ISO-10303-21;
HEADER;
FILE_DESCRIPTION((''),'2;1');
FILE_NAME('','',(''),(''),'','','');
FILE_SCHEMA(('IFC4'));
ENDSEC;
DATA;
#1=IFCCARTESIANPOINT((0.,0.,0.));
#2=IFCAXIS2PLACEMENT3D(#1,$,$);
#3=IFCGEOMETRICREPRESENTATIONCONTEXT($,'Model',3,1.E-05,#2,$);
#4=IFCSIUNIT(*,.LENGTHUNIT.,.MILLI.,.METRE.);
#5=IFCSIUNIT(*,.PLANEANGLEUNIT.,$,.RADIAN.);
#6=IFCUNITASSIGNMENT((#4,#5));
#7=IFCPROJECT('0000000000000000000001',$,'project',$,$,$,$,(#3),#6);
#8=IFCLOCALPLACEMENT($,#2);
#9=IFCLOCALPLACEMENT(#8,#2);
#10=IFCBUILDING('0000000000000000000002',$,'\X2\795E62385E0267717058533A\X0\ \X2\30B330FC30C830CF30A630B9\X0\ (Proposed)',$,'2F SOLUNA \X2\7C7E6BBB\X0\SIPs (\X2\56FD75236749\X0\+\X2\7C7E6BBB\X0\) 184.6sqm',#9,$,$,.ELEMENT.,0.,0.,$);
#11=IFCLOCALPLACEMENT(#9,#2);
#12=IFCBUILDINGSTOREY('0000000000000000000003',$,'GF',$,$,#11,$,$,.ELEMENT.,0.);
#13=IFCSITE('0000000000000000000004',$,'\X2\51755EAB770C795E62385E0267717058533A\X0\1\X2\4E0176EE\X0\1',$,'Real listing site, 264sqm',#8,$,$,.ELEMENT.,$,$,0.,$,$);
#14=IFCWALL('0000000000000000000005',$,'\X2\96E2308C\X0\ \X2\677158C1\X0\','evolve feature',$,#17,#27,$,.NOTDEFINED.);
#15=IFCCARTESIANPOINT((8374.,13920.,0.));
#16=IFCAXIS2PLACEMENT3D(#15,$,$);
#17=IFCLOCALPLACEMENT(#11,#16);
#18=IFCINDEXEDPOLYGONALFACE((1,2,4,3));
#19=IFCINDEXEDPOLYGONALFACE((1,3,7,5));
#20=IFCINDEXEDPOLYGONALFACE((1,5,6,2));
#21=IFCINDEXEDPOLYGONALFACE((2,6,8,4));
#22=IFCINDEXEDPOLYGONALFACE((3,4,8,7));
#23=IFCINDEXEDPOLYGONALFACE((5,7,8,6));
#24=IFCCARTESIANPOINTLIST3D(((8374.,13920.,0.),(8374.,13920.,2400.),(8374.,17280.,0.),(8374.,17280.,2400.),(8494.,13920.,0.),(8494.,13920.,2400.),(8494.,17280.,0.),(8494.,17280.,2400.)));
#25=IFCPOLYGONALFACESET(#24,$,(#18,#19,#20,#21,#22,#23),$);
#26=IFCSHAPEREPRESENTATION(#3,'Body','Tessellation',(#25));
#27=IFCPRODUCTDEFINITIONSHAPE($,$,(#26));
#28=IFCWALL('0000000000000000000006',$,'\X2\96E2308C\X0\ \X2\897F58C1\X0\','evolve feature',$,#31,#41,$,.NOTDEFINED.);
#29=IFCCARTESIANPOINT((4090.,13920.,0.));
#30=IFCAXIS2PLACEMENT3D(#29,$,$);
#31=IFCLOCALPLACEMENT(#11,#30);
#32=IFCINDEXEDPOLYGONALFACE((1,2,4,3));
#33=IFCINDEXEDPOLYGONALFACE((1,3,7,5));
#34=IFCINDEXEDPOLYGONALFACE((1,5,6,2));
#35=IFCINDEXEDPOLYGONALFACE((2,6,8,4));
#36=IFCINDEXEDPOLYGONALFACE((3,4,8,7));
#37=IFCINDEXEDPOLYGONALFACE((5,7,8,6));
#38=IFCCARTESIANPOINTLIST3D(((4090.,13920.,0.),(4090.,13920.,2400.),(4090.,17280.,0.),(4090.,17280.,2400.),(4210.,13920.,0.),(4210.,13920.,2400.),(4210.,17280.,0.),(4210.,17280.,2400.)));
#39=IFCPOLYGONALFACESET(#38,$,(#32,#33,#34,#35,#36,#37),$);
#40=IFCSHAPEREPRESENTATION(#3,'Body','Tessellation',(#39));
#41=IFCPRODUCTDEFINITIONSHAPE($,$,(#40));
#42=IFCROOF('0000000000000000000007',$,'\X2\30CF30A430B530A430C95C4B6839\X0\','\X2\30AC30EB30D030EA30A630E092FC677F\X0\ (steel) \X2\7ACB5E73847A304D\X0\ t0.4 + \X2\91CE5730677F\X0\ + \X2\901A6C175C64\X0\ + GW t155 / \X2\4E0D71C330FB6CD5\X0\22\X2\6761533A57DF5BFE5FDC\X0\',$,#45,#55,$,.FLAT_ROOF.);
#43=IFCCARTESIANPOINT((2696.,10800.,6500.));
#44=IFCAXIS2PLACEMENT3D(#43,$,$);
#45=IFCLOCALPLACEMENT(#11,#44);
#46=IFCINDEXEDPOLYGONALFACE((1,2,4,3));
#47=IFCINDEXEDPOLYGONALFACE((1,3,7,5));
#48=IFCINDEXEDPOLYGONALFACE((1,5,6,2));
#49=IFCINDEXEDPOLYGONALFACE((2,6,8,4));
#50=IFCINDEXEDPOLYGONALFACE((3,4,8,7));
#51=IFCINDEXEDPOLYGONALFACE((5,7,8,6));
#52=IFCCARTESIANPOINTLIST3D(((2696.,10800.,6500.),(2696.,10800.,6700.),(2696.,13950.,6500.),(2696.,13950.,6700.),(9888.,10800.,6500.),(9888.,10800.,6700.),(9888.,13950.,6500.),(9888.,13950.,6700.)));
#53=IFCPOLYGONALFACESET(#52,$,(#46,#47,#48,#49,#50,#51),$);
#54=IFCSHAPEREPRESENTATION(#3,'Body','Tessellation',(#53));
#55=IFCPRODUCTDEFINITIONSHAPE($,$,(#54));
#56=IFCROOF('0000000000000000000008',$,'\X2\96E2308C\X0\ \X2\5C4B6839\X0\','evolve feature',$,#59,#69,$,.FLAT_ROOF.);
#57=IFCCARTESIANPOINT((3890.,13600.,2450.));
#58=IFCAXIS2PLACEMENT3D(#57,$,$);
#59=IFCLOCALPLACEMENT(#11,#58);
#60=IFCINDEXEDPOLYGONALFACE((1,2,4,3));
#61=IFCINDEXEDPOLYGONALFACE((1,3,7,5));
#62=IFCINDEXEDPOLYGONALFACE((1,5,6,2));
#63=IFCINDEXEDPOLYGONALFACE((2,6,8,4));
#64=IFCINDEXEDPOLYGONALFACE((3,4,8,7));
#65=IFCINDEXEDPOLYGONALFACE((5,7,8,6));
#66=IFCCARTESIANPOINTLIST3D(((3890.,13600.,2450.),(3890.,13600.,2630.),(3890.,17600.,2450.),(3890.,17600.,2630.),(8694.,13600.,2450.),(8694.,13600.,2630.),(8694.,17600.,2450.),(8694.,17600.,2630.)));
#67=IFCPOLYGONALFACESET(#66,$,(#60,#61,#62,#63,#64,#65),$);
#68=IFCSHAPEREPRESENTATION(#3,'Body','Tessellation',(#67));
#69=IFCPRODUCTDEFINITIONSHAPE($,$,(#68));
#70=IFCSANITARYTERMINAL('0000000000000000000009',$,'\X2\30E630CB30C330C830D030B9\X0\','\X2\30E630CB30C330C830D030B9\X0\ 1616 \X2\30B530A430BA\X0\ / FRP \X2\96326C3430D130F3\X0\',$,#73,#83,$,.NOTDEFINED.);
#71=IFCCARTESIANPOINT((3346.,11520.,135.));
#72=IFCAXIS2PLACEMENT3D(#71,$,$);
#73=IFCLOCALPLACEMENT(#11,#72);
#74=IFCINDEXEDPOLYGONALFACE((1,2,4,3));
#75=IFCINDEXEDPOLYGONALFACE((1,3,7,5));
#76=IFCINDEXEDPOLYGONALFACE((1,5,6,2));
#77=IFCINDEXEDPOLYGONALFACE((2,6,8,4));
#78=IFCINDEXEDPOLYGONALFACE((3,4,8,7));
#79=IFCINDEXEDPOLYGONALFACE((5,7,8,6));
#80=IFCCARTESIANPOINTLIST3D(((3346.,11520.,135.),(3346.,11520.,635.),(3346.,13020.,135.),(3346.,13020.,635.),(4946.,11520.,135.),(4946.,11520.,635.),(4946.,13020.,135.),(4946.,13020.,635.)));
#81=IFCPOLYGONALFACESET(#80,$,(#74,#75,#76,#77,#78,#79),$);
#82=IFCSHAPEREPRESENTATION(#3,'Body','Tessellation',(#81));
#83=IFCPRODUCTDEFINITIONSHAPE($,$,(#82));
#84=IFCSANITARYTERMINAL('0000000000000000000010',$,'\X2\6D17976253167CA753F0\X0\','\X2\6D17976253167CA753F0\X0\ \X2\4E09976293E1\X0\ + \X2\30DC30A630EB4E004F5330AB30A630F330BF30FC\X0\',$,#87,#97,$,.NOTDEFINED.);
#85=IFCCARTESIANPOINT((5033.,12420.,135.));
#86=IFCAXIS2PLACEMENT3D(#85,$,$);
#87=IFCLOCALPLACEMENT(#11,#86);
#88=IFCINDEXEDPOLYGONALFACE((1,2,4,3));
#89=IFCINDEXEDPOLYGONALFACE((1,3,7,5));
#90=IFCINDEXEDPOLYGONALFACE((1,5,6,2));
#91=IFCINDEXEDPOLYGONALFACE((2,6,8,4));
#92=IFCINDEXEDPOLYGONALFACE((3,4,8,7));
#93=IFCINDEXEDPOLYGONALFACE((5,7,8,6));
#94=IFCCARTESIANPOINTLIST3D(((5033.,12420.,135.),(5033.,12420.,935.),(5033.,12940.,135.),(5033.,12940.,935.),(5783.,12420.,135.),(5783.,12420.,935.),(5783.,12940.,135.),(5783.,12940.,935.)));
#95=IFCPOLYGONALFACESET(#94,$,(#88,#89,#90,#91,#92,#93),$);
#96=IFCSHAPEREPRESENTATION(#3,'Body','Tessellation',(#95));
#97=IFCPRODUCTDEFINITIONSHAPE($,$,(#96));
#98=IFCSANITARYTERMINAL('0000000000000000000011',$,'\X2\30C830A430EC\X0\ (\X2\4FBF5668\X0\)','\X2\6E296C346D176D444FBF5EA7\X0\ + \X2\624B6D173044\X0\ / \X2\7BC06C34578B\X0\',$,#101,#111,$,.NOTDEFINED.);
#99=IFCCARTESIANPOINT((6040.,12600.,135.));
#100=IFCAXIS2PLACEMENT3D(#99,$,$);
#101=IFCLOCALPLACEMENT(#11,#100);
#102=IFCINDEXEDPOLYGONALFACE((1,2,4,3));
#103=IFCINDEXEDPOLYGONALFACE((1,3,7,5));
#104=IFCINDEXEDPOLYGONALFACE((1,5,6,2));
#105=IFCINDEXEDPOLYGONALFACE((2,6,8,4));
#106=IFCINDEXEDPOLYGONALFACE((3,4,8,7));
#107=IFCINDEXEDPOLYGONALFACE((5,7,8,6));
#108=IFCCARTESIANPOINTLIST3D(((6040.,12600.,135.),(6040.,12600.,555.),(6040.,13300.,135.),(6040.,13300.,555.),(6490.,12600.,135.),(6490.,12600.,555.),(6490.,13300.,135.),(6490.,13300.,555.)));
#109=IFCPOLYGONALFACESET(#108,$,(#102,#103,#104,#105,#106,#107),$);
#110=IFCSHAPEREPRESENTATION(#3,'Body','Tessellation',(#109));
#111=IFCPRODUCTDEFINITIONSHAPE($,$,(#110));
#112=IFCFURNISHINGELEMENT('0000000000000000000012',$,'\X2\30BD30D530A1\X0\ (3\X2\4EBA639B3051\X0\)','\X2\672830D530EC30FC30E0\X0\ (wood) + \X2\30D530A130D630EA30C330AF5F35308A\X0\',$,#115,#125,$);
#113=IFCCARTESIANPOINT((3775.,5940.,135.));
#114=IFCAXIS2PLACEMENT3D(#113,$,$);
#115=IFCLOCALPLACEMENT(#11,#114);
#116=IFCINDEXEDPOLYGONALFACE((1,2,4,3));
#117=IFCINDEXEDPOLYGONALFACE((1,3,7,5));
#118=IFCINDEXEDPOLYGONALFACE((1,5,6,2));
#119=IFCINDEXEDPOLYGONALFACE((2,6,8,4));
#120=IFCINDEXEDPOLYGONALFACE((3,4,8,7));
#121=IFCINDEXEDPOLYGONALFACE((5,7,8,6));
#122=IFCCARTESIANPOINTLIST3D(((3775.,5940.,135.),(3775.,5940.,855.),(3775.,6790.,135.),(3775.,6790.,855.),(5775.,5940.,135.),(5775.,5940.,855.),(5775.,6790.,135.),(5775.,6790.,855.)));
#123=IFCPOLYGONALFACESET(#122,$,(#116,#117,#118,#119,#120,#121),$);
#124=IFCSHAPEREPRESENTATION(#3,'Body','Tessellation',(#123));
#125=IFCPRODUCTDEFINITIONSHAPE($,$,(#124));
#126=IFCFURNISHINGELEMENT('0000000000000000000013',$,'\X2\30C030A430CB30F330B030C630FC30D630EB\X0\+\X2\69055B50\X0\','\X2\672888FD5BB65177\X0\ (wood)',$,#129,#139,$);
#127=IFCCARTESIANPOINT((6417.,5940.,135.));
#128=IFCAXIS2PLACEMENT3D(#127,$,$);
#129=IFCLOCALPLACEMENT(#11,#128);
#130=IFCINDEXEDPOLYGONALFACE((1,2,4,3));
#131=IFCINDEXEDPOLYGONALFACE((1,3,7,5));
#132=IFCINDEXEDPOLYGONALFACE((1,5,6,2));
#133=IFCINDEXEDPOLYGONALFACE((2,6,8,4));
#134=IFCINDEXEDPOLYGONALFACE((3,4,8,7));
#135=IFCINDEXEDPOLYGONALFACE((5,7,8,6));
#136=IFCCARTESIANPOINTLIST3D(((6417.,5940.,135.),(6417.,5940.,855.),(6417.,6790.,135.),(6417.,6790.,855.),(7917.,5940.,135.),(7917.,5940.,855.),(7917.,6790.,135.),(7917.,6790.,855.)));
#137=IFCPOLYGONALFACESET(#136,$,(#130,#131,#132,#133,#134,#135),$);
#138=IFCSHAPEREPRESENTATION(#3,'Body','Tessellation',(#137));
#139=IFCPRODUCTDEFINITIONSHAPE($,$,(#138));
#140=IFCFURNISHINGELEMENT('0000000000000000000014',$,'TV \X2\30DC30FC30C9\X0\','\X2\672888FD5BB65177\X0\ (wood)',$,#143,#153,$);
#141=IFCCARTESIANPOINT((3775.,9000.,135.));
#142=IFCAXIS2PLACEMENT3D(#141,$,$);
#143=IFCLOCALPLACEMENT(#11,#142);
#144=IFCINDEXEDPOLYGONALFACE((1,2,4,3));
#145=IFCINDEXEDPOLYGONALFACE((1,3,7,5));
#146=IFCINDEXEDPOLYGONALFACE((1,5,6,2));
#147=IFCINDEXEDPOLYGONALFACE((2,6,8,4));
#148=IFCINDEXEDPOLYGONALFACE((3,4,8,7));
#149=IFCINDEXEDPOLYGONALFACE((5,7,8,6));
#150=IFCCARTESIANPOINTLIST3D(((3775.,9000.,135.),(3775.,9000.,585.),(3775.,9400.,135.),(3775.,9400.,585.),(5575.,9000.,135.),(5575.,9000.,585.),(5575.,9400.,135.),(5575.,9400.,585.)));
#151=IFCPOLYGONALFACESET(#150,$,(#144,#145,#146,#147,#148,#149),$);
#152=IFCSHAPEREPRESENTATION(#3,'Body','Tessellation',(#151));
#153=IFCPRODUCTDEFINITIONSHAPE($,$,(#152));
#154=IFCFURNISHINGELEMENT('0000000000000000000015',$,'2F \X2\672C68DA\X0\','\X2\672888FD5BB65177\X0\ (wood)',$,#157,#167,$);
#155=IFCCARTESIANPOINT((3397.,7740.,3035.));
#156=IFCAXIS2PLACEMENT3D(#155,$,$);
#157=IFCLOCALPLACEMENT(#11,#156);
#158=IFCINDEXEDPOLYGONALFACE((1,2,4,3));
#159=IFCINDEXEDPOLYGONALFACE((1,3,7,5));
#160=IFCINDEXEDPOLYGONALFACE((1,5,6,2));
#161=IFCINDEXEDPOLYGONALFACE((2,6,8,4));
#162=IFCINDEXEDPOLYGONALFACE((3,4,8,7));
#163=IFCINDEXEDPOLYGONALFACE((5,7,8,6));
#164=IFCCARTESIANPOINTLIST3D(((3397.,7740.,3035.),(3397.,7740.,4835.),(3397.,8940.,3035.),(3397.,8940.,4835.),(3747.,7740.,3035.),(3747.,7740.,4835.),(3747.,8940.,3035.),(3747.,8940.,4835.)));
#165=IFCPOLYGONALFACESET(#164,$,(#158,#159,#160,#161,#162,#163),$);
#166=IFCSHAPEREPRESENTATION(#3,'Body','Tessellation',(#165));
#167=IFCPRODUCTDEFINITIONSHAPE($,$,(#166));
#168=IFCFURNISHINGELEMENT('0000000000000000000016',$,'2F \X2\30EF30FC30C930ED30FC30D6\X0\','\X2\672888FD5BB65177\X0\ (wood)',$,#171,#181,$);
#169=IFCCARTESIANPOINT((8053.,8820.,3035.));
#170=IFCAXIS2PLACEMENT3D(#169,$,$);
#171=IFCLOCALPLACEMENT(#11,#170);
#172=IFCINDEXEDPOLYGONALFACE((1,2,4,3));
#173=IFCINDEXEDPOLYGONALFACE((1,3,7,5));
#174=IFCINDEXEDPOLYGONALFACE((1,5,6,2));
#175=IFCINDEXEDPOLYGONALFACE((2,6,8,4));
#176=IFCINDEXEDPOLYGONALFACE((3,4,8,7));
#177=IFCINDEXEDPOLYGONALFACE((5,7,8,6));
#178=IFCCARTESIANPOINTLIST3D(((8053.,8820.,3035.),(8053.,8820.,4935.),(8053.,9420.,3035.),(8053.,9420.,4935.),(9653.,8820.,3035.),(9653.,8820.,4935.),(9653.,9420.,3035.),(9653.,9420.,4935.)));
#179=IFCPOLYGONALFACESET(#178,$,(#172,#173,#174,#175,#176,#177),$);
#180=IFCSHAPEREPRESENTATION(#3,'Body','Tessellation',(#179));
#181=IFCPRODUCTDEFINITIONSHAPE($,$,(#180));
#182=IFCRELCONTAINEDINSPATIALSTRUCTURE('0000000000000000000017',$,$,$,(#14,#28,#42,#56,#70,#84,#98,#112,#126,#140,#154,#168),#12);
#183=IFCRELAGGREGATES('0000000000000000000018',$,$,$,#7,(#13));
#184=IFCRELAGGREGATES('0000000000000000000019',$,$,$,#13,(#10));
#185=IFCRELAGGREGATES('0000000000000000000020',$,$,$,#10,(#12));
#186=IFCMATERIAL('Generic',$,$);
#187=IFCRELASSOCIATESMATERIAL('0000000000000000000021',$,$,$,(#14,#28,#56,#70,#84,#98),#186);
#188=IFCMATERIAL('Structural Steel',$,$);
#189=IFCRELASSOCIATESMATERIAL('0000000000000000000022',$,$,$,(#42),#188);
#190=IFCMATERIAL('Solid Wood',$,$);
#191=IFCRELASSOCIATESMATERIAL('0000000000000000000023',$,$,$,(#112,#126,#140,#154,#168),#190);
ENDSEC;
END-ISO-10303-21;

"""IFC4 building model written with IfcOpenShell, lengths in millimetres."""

from ifc_helpers import new_model, si_unit, frame, frame_2d, origin, place, context, project, spatial, rectangle, extrude, material, element, save


model = new_model("IFC4")

# Units and contexts
model_context = context("Model", 3, precision=1e-05, world=origin())
ifc_project = project(units=[si_unit("LENGTHUNIT", "METRE", prefix="MILLI"), si_unit("PLANEANGLEUNIT", "RADIAN")], contexts=[model_context])

# Site, building, storey
site_placement = place(None, origin())
site = spatial("IfcSite", under=ifc_project, at=site_placement, Name="兵庫県神戸市東灘区1丁目1", ObjectType="Real listing site, 264sqm", CompositionType="ELEMENT", RefElevation=0.0)
building_placement = place(site_placement, origin())
building = spatial("IfcBuilding", under=site, at=building_placement, Name="神戸市東灘区 コートハウス (Proposed)", ObjectType="2F SOLUNA 籾殻SIPs (国産杉+籾殻) 184.6sqm", CompositionType="ELEMENT", ElevationOfRefHeight=0.0, ElevationOfTerrain=0.0)
storey_placement = place(building_placement, origin())
storey = spatial("IfcBuildingStorey", under=building, at=storey_placement, Name="GF", CompositionType="ELEMENT", Elevation=0.0)

# Shared definitions
ifc_material_1 = material(Name="Generic")

# Shared definitions
ifc_material_2 = material(Name="Solid Wood")

# Walls
wall_1_placement = place(storey_placement, frame((8374.0, 13920.0, 0.0)))
element("IfcWall", 1, at=wall_1_placement, inside=storey, material=ifc_material_1, Name="離れ 東壁", Description="evolve feature", PredefinedType="NOTDEFINED", context=model_context, shape_type="SweptSolid", body=[
    extrude(rectangle(XDim=120.0, YDim=3360.0, at=frame_2d((60.0, 1680.0))), frame((8374.0, 13920.0, 0.0)), (0.0, 0.0, 1.0), 2400.0),
])
wall_2_placement = place(storey_placement, frame((4090.0, 13920.0, 0.0)))
element("IfcWall", 2, at=wall_2_placement, inside=storey, material=ifc_material_1, Name="離れ 西壁", Description="evolve feature", PredefinedType="NOTDEFINED", context=model_context, shape_type="SweptSolid", body=[
    extrude(rectangle(XDim=120.0, YDim=3360.0, at=frame_2d((60.0, 1680.0))), frame((4090.0, 13920.0, 0.0)), (0.0, 0.0, 1.0), 2400.0),
])

# Roofs
ifc_material_3 = material(Name="Structural Steel")
roof_1_placement = place(storey_placement, frame((2696.0, 10800.0, 6500.0)))
element("IfcRoof", 3, at=roof_1_placement, inside=storey, material=ifc_material_3, Name="ハイサイド屋根", Description="ガルバリウム鋼板 (steel) 立平葺き t0.4 + 野地板 + 通気層 + GW t155 / 不燃・法22条区域対応", PredefinedType="FLAT_ROOF", context=model_context, shape_type="SweptSolid", body=[
    extrude(rectangle(XDim=7192.0, YDim=3150.0, at=frame_2d((3596.0, 1575.0))), frame((2696.0, 10800.0, 6500.0)), (0.0, 0.0, 1.0), 200.0),
])
roof_2_placement = place(storey_placement, frame((3890.0, 13600.0, 2450.0)))
element("IfcRoof", 4, at=roof_2_placement, inside=storey, material=ifc_material_1, Name="離れ 屋根", Description="evolve feature", PredefinedType="FLAT_ROOF", context=model_context, shape_type="SweptSolid", body=[
    extrude(rectangle(XDim=4804.0, YDim=4000.0, at=frame_2d((2402.0, 2000.0))), frame((3890.0, 13600.0, 2450.0)), (0.0, 0.0, 1.0), 180.0),
])

# Sanitary terminals
sanitary_terminal_1_placement = place(storey_placement, frame((3346.0, 11520.0, 135.0)))
element("IfcSanitaryTerminal", 5, at=sanitary_terminal_1_placement, inside=storey, material=ifc_material_1, Name="ユニットバス", Description="ユニットバス 1616 サイズ / FRP 防水パン", PredefinedType="NOTDEFINED", context=model_context, shape_type="SweptSolid", body=[
    extrude(rectangle(XDim=1600.0, YDim=1500.0, at=frame_2d((800.0, 750.0))), frame((3346.0, 11520.0, 135.0)), (0.0, 0.0, 1.0), 500.0),
])
sanitary_terminal_2_placement = place(storey_placement, frame((5033.0, 12420.0, 135.0)))
element("IfcSanitaryTerminal", 6, at=sanitary_terminal_2_placement, inside=storey, material=ifc_material_1, Name="洗面化粧台", Description="洗面化粧台 三面鏡 + ボウル一体カウンター", PredefinedType="NOTDEFINED", context=model_context, shape_type="SweptSolid", body=[
    extrude(rectangle(XDim=750.0, YDim=520.0, at=frame_2d((375.0, 260.0))), frame((5033.0, 12420.0, 135.0)), (0.0, 0.0, 1.0), 800.0),
])
sanitary_terminal_3_placement = place(storey_placement, frame((6040.0, 12600.0, 135.0)))
element("IfcSanitaryTerminal", 7, at=sanitary_terminal_3_placement, inside=storey, material=ifc_material_1, Name="トイレ (便器)", Description="温水洗浄便座 + 手洗い / 節水型", PredefinedType="NOTDEFINED", context=model_context, shape_type="SweptSolid", body=[
    extrude(rectangle(XDim=450.0, YDim=700.0, at=frame_2d((225.0, 350.0))), frame((6040.0, 12600.0, 135.0)), (0.0, 0.0, 1.0), 420.0),
])

# Furnishing elements
furnishing_1_placement = place(storey_placement, frame((3775.0, 5940.0, 135.0)))
element("IfcFurnishingElement", 8, at=furnishing_1_placement, inside=storey, material=ifc_material_2, Name="ソファ (3人掛け)", Description="木フレーム (wood) + ファブリック張り", context=model_context, shape_type="SweptSolid", body=[
    extrude(rectangle(XDim=2000.0, YDim=850.0, at=frame_2d((1000.0, 425.0))), frame((3775.0, 5940.0, 135.0)), (0.0, 0.0, 1.0), 720.0),
])
furnishing_2_placement = place(storey_placement, frame((6417.0, 5940.0, 135.0)))
element("IfcFurnishingElement", 9, at=furnishing_2_placement, inside=storey, material=ifc_material_2, Name="ダイニングテーブル+椅子", Description="木製家具 (wood)", context=model_context, shape_type="SweptSolid", body=[
    extrude(rectangle(XDim=1500.0, YDim=850.0, at=frame_2d((750.0, 425.0))), frame((6417.0, 5940.0, 135.0)), (0.0, 0.0, 1.0), 720.0),
])
furnishing_3_placement = place(storey_placement, frame((3775.0, 9000.0, 135.0)))
element("IfcFurnishingElement", 10, at=furnishing_3_placement, inside=storey, material=ifc_material_2, Name="TV ボード", Description="木製家具 (wood)", context=model_context, shape_type="SweptSolid", body=[
    extrude(rectangle(XDim=1800.0, YDim=400.0, at=frame_2d((900.0, 200.0))), frame((3775.0, 9000.0, 135.0)), (0.0, 0.0, 1.0), 450.0),
])
furnishing_4_placement = place(storey_placement, frame((3397.0, 7740.0, 3035.0)))
element("IfcFurnishingElement", 11, at=furnishing_4_placement, inside=storey, material=ifc_material_2, Name="2F 本棚", Description="木製家具 (wood)", context=model_context, shape_type="SweptSolid", body=[
    extrude(rectangle(XDim=350.0, YDim=1200.0, at=frame_2d((175.0, 600.0))), frame((3397.0, 7740.0, 3035.0)), (0.0, 0.0, 1.0), 1800.0),
])
furnishing_5_placement = place(storey_placement, frame((8053.0, 8820.0, 3035.0)))
element("IfcFurnishingElement", 12, at=furnishing_5_placement, inside=storey, material=ifc_material_2, Name="2F ワードローブ", Description="木製家具 (wood)", context=model_context, shape_type="SweptSolid", body=[
    extrude(rectangle(XDim=1600.0, YDim=600.0, at=frame_2d((800.0, 300.0))), frame((8053.0, 8820.0, 3035.0)), (0.0, 0.0, 1.0), 1900.0),
])

save(model, "model.ifc")
